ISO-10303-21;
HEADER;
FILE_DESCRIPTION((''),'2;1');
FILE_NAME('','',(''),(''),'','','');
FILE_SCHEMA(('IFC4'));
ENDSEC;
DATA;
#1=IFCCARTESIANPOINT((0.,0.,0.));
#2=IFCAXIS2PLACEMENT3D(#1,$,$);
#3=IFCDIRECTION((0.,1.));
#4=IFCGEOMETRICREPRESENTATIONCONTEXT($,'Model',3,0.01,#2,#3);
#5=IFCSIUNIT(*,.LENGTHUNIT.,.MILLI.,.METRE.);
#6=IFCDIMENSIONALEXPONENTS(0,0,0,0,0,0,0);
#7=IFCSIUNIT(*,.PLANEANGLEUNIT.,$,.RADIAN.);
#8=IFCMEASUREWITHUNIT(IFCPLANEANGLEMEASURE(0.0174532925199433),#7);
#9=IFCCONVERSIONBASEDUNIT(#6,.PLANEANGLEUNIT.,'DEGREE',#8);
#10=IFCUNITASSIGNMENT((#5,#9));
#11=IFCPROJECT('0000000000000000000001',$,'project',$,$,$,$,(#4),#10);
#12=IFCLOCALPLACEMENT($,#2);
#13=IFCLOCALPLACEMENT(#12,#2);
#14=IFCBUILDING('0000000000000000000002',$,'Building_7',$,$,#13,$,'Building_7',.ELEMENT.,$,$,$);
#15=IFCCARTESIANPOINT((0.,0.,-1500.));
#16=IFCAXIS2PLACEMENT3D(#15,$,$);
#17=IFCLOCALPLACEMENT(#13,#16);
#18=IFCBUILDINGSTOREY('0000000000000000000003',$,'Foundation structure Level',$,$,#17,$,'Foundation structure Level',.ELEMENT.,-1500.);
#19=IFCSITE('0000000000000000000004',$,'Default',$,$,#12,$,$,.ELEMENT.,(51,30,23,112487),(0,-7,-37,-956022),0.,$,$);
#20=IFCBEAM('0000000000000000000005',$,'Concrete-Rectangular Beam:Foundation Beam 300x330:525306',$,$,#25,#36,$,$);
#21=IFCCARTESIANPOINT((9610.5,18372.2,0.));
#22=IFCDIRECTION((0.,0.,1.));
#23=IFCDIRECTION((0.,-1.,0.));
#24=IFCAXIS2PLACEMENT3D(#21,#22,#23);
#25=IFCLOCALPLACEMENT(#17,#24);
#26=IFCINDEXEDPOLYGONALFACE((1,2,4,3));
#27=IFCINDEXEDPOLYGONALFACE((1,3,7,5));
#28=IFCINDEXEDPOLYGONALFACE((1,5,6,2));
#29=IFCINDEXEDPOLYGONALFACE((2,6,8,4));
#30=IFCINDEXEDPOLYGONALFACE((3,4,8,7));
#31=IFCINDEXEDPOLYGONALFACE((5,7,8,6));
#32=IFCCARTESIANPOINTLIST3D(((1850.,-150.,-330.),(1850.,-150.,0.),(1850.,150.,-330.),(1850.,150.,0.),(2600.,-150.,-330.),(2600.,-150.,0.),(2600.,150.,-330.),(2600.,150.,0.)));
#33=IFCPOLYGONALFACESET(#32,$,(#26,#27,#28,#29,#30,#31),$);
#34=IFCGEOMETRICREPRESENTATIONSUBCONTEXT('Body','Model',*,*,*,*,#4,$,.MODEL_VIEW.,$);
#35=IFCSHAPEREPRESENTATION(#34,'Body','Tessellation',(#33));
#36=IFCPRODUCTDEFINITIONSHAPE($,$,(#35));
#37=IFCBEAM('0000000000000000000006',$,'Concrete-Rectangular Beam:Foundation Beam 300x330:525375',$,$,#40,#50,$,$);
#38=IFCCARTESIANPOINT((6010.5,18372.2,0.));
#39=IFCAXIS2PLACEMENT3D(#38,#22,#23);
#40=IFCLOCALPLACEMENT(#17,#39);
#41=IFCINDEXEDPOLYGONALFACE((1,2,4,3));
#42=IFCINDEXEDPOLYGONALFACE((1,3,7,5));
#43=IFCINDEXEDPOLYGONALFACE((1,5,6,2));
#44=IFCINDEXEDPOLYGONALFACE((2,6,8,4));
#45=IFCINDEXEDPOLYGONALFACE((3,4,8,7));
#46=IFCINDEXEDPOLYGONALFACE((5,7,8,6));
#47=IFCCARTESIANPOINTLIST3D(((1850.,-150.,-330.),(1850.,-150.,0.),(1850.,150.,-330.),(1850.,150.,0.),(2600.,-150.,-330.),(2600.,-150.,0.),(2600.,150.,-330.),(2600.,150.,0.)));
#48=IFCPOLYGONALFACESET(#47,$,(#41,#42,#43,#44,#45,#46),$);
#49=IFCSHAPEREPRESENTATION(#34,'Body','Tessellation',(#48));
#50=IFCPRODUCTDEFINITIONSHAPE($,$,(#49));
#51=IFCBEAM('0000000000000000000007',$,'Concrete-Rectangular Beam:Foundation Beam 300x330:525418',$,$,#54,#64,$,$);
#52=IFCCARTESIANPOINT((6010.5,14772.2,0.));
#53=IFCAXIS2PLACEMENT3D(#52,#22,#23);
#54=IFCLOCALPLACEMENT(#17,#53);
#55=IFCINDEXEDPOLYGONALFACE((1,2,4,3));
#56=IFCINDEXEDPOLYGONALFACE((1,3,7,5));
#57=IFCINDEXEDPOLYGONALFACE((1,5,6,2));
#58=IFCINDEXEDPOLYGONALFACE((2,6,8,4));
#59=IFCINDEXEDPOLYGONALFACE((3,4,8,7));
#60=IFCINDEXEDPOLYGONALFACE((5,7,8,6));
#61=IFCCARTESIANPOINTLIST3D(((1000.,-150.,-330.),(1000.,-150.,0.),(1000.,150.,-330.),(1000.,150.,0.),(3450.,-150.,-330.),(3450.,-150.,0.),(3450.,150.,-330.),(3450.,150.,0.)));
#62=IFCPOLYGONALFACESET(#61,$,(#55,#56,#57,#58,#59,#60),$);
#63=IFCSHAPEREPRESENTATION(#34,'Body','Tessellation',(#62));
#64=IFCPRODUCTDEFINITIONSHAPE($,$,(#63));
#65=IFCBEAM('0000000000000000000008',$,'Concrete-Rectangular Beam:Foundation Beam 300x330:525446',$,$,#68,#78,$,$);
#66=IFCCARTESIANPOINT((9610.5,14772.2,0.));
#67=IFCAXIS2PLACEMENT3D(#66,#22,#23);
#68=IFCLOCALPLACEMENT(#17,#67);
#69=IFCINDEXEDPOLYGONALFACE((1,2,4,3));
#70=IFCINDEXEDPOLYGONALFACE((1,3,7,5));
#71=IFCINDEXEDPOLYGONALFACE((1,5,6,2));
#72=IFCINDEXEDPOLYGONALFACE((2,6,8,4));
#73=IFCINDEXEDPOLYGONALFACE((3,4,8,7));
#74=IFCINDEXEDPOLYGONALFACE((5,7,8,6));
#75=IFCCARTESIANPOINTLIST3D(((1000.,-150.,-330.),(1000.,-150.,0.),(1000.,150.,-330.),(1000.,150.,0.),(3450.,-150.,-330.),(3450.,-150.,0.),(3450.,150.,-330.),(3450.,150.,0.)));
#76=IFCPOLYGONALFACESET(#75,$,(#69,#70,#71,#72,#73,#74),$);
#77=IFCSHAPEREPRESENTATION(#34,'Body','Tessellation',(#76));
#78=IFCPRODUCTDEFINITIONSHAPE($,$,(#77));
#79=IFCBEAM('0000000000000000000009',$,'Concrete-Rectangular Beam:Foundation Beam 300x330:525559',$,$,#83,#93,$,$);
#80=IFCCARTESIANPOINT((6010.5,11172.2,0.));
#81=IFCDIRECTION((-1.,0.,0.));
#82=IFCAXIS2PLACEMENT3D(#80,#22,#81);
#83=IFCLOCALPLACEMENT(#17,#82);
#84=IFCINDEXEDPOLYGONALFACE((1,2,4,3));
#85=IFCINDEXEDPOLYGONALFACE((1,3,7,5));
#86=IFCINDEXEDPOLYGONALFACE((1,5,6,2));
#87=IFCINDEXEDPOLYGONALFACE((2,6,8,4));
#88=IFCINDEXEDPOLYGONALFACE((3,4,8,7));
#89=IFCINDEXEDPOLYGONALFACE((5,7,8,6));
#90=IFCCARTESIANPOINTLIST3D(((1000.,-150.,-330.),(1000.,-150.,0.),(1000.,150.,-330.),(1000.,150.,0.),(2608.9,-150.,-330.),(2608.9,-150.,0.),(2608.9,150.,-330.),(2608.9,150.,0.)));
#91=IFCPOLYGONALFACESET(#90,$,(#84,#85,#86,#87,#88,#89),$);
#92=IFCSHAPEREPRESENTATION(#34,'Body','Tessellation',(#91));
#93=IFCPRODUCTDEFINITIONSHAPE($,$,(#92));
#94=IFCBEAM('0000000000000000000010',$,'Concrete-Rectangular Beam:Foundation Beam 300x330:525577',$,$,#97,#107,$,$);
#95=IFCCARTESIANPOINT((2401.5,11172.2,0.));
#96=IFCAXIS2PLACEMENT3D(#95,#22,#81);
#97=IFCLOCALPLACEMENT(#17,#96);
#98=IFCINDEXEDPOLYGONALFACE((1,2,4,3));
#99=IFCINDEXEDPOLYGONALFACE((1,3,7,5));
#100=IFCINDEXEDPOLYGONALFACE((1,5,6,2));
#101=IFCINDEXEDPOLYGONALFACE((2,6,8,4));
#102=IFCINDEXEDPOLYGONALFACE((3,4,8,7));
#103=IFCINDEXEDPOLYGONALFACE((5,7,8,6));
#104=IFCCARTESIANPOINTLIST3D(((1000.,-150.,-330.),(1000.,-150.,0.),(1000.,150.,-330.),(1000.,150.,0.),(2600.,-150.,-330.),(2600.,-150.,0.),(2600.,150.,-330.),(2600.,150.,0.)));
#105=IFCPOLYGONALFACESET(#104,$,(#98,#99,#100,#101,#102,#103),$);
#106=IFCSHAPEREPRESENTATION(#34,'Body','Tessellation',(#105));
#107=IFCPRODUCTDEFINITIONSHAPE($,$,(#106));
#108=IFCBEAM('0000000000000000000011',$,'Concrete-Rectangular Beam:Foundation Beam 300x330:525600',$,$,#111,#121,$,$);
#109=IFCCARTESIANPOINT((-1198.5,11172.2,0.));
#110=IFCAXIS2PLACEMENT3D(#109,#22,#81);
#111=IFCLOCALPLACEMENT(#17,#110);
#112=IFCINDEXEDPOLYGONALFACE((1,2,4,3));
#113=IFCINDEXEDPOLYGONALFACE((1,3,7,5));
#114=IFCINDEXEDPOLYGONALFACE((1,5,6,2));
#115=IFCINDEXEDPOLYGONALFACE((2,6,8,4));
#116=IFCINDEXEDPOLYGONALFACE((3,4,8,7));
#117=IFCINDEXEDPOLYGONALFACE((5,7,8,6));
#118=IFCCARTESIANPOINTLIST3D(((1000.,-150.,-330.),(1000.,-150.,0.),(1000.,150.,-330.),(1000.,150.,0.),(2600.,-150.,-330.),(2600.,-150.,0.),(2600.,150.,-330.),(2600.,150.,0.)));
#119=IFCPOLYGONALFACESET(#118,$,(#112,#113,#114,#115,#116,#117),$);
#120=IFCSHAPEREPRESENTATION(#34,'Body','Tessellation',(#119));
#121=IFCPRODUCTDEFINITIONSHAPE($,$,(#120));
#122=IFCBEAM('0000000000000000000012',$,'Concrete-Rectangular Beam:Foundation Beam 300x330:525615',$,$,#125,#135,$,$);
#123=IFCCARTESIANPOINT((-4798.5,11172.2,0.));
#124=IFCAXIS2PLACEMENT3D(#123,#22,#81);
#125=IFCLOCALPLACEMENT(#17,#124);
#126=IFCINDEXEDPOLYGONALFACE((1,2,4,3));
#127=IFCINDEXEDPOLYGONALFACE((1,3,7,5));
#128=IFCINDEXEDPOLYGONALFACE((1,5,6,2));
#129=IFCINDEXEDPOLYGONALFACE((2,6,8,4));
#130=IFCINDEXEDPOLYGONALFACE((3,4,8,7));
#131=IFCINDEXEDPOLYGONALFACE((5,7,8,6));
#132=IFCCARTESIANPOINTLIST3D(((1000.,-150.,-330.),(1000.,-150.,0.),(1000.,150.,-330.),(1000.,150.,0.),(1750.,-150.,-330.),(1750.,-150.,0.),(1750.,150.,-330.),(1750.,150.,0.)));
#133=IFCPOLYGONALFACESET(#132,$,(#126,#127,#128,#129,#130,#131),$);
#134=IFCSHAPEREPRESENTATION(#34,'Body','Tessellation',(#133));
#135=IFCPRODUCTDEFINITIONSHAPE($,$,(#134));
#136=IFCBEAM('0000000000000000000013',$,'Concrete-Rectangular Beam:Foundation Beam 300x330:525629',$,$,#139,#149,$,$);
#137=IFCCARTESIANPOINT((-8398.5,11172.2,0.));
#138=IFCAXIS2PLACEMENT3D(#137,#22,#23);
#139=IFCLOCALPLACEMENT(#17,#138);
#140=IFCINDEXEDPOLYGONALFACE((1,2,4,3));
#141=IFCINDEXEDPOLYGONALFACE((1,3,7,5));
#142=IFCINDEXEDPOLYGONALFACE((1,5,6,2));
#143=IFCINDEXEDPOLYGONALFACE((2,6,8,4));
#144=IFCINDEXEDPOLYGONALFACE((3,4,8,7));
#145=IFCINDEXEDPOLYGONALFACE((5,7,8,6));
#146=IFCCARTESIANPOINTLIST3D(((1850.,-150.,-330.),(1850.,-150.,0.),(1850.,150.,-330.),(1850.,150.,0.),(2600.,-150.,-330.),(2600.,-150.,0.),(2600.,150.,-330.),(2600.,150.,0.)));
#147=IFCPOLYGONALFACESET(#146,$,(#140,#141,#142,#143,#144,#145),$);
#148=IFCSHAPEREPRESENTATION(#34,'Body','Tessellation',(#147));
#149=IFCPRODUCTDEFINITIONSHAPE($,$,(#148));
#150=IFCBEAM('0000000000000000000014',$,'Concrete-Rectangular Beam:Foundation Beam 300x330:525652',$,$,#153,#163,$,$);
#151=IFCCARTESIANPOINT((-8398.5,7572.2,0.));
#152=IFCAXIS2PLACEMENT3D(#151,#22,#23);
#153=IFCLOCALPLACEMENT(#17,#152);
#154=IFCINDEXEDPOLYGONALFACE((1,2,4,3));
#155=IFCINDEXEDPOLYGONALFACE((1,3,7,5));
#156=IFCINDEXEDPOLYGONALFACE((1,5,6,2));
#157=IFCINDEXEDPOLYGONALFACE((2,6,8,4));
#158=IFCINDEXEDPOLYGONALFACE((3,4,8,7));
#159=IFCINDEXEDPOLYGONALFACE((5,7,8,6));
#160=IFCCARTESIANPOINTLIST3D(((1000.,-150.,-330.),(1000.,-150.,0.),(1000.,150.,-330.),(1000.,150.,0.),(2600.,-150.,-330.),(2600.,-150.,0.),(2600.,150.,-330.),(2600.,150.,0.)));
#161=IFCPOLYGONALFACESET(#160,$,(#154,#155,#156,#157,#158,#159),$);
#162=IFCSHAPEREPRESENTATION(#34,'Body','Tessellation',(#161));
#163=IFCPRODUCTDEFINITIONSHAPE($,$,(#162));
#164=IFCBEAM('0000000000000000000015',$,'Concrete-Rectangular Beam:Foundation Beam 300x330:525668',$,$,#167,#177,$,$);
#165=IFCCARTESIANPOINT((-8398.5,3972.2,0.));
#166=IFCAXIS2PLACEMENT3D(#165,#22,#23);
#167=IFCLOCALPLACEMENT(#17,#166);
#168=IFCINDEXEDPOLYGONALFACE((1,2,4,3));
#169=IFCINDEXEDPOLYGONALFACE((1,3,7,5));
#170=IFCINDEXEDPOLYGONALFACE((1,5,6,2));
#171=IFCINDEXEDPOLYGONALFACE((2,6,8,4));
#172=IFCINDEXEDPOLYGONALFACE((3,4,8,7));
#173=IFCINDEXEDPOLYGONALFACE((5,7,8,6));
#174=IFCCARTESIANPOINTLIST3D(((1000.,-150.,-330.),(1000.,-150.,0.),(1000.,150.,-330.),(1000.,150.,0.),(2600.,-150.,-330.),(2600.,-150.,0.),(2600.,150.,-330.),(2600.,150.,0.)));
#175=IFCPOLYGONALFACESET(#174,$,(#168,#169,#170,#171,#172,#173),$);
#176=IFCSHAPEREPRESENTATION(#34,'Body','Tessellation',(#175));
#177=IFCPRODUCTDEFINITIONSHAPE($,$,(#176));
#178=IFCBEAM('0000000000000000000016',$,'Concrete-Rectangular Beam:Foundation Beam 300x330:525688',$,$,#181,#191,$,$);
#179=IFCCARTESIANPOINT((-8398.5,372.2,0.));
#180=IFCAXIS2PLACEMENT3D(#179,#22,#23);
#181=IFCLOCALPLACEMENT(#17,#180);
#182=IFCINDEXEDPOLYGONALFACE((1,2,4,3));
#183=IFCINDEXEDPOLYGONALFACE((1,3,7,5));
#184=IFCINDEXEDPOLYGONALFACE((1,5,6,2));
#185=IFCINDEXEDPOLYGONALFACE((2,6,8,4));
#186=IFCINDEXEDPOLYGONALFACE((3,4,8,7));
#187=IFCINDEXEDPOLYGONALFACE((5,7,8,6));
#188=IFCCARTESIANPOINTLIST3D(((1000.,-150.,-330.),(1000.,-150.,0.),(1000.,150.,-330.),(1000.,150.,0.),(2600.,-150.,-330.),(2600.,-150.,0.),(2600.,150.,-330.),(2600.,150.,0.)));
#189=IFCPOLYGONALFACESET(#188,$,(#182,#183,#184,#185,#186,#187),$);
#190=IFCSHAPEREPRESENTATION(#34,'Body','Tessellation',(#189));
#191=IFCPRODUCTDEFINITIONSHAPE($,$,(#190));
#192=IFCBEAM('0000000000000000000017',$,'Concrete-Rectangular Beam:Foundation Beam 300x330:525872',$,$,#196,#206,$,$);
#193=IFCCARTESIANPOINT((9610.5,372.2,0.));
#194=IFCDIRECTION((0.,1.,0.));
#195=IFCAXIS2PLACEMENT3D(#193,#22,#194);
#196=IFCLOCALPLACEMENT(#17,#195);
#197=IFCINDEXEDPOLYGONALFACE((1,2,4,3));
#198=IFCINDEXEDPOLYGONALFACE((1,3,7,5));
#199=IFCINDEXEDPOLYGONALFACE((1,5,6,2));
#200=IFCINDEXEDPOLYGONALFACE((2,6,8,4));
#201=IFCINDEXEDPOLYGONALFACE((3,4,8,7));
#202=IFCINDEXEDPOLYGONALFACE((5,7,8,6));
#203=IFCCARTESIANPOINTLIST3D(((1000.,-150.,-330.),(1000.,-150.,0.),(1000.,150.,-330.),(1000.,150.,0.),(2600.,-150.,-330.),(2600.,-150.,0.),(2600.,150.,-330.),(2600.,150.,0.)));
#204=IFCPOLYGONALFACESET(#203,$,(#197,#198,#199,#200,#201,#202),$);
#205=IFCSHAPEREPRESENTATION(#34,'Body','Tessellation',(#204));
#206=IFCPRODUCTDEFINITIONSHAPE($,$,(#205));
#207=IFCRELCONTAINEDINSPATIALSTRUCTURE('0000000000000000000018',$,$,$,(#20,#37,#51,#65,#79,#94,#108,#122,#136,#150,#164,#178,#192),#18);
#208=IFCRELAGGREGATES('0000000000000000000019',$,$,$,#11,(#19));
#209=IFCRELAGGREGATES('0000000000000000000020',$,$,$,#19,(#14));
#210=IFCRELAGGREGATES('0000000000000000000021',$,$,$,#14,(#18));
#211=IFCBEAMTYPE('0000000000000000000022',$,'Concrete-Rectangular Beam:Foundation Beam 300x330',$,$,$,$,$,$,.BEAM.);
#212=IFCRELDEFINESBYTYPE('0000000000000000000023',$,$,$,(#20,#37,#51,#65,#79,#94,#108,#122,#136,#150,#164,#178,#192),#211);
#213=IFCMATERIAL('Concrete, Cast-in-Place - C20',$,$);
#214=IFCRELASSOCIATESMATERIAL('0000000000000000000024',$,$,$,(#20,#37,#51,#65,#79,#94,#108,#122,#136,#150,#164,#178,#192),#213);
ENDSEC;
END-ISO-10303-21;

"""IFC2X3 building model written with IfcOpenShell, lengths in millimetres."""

from ifc_helpers import new_model, entity, si_unit, converted_unit, direction, frame, frame_2d, origin, place, context, subcontext, project, spatial, rectangle, extrude, material, type_object, element, save


model = new_model("IFC2X3")

# Units and contexts
model_context = context("Model", 3, precision=0.01, world=origin(), true_north=direction((0.0, 1.0)))
body_context = subcontext(model_context, "Body", "Model", "MODEL_VIEW")
ifc_project = project(units=[si_unit("LENGTHUNIT", "METRE", prefix="MILLI"), converted_unit("PLANEANGLEUNIT", "DEGREE", entity("IfcPlaneAngleMeasure", 0.0174532925199433), si_unit("PLANEANGLEUNIT", "RADIAN"), dimensions=[0, 0, 0, 0, 0, 0, 0])], contexts=[model_context])

# Site, building, storey
site_placement = place(None, origin())
site = spatial("IfcSite", under=ifc_project, at=site_placement, Name="Default", CompositionType="ELEMENT", RefLatitude=(51, 30, 23, 112487), RefLongitude=(0, -7, -37, -956022), RefElevation=0.0)
building_placement = place(site_placement, origin())
building = spatial("IfcBuilding", under=site, at=building_placement, Name="Building_7", LongName="Building_7", CompositionType="ELEMENT")
storey_placement = place(building_placement, frame((0.0, 0.0, -1500.0)))
storey = spatial("IfcBuildingStorey", under=building, at=storey_placement, Name="Foundation structure Level", LongName="Foundation structure Level", CompositionType="ELEMENT", Elevation=-1500.0)

# Beams
ifc_material_1 = material(Name="Concrete, Cast-in-Place - C20")
beam_type = type_object("IfcBeamType", Name="Concrete-Rectangular Beam:Foundation Beam 300x330", PredefinedType="BEAM")
beam_1_placement = place(storey_placement, frame((9610.5, 18372.2, 0.0), z_axis=(0.0, 0.0, 1.0), x_axis=(0.0, -1.0, 0.0)))
element("IfcBeam", 1, at=beam_1_placement, inside=storey, type_object=beam_type, material=ifc_material_1, Name="Concrete-Rectangular Beam:Foundation Beam 300x330:525306", context=body_context, shape_type="SweptSolid", body=[
    extrude(rectangle(XDim=330.0, YDim=300.0, at=frame_2d((0.0, 0.0), x_axis=(1.0, 0.0))), frame((1850.0, 0.0, -165.0), z_axis=(1.0, 0.0, 0.0), x_axis=(0.0, 0.0, -1.0)), (0.0, 0.0, 1.0), 750.0),
])
beam_2_placement = place(storey_placement, frame((6010.5, 18372.2, 0.0), z_axis=(0.0, 0.0, 1.0), x_axis=(0.0, -1.0, 0.0)))
element("IfcBeam", 2, at=beam_2_placement, inside=storey, type_object=beam_type, material=ifc_material_1, Name="Concrete-Rectangular Beam:Foundation Beam 300x330:525375", context=body_context, shape_type="SweptSolid", body=[
    extrude(rectangle(XDim=330.0, YDim=300.0, at=frame_2d((0.0, 0.0), x_axis=(1.0, 0.0))), frame((1850.0, 0.0, -165.0), z_axis=(1.0, 0.0, 0.0), x_axis=(0.0, 0.0, -1.0)), (0.0, 0.0, 1.0), 750.0),
])
beam_3_placement = place(storey_placement, frame((6010.5, 14772.2, 0.0), z_axis=(0.0, 0.0, 1.0), x_axis=(0.0, -1.0, 0.0)))
element("IfcBeam", 3, at=beam_3_placement, inside=storey, type_object=beam_type, material=ifc_material_1, Name="Concrete-Rectangular Beam:Foundation Beam 300x330:525418", context=body_context, shape_type="SweptSolid", body=[
    extrude(rectangle(XDim=330.0, YDim=300.0, at=frame_2d((0.0, 0.0), x_axis=(1.0, 0.0))), frame((1000.0, 0.0, -165.0), z_axis=(1.0, 0.0, 0.0), x_axis=(0.0, 0.0, -1.0)), (0.0, 0.0, 1.0), 2450.0),
])
beam_4_placement = place(storey_placement, frame((9610.5, 14772.2, 0.0), z_axis=(0.0, 0.0, 1.0), x_axis=(0.0, -1.0, 0.0)))
element("IfcBeam", 4, at=beam_4_placement, inside=storey, type_object=beam_type, material=ifc_material_1, Name="Concrete-Rectangular Beam:Foundation Beam 300x330:525446", context=body_context, shape_type="SweptSolid", body=[
    extrude(rectangle(XDim=330.0, YDim=300.0, at=frame_2d((0.0, 0.0), x_axis=(1.0, 0.0))), frame((1000.0, 0.0, -165.0), z_axis=(1.0, 0.0, 0.0), x_axis=(0.0, 0.0, -1.0)), (0.0, 0.0, 1.0), 2450.0),
])
beam_5_placement = place(storey_placement, frame((6010.5, 11172.2, 0.0), z_axis=(0.0, 0.0, 1.0), x_axis=(-1.0, 0.0, 0.0)))
element("IfcBeam", 5, at=beam_5_placement, inside=storey, type_object=beam_type, material=ifc_material_1, Name="Concrete-Rectangular Beam:Foundation Beam 300x330:525559", context=body_context, shape_type="SweptSolid", body=[
    extrude(rectangle(XDim=330.0, YDim=300.0, at=frame_2d((0.0, 0.0), x_axis=(1.0, 0.0))), frame((1000.0, 0.0, -165.0), z_axis=(1.0, 0.0, 0.0), x_axis=(0.0, 0.0, -1.0)), (0.0, 0.0, 1.0), 1608.9),
])
for number, where, z_axis, x_axis, name in (
    (6, (2401.5, 11172.2, 0.0), (0.0, 0.0, 1.0), (-1.0, 0.0, 0.0), "Concrete-Rectangular Beam:Foundation Beam 300x330:525577"),
    (7, (-1198.5, 11172.2, 0.0), (0.0, 0.0, 1.0), (-1.0, 0.0, 0.0), "Concrete-Rectangular Beam:Foundation Beam 300x330:525600"),
):
    element("IfcBeam", number, at=place(storey_placement, frame(where, z_axis=z_axis, x_axis=x_axis)), inside=storey, type_object=beam_type, material=ifc_material_1, Name=name, context=body_context, shape_type="SweptSolid", body=[
        extrude(rectangle(XDim=330.0, YDim=300.0, at=frame_2d((0.0, 0.0), x_axis=(1.0, 0.0))), frame((1000.0, 0.0, -165.0), z_axis=(1.0, 0.0, 0.0), x_axis=(0.0, 0.0, -1.0)), (0.0, 0.0, 1.0), 1600.0),
    ])
beam_6_placement = place(storey_placement, frame((-4798.5, 11172.2, 0.0), z_axis=(0.0, 0.0, 1.0), x_axis=(-1.0, 0.0, 0.0)))
element("IfcBeam", 8, at=beam_6_placement, inside=storey, type_object=beam_type, material=ifc_material_1, Name="Concrete-Rectangular Beam:Foundation Beam 300x330:525615", context=body_context, shape_type="SweptSolid", body=[
    extrude(rectangle(XDim=330.0, YDim=300.0, at=frame_2d((0.0, 0.0), x_axis=(1.0, 0.0))), frame((1000.0, 0.0, -165.0), z_axis=(1.0, 0.0, 0.0), x_axis=(0.0, 0.0, -1.0)), (0.0, 0.0, 1.0), 750.0),
])
beam_7_placement = place(storey_placement, frame((-8398.5, 11172.2, 0.0), z_axis=(0.0, 0.0, 1.0), x_axis=(0.0, -1.0, 0.0)))
element("IfcBeam", 9, at=beam_7_placement, inside=storey, type_object=beam_type, material=ifc_material_1, Name="Concrete-Rectangular Beam:Foundation Beam 300x330:525629", context=body_context, shape_type="SweptSolid", body=[
    extrude(rectangle(XDim=330.0, YDim=300.0, at=frame_2d((0.0, 0.0), x_axis=(1.0, 0.0))), frame((1850.0, 0.0, -165.0), z_axis=(1.0, 0.0, 0.0), x_axis=(0.0, 0.0, -1.0)), (0.0, 0.0, 1.0), 750.0),
])
for number, where, z_axis, x_axis, name in (
    (10, (-8398.5, 7572.2, 0.0), (0.0, 0.0, 1.0), (0.0, -1.0, 0.0), "Concrete-Rectangular Beam:Foundation Beam 300x330:525652"),
    (11, (-8398.5, 3972.2, 0.0), (0.0, 0.0, 1.0), (0.0, -1.0, 0.0), "Concrete-Rectangular Beam:Foundation Beam 300x330:525668"),
    (12, (-8398.5, 372.2, 0.0), (0.0, 0.0, 1.0), (0.0, -1.0, 0.0), "Concrete-Rectangular Beam:Foundation Beam 300x330:525688"),
):
    element("IfcBeam", number, at=place(storey_placement, frame(where, z_axis=z_axis, x_axis=x_axis)), inside=storey, type_object=beam_type, material=ifc_material_1, Name=name, context=body_context, shape_type="SweptSolid", body=[
        extrude(rectangle(XDim=330.0, YDim=300.0, at=frame_2d((0.0, 0.0), x_axis=(1.0, 0.0))), frame((1000.0, 0.0, -165.0), z_axis=(1.0, 0.0, 0.0), x_axis=(0.0, 0.0, -1.0)), (0.0, 0.0, 1.0), 1600.0),
    ])
beam_8_placement = place(storey_placement, frame((9610.5, 372.2, 0.0), z_axis=(0.0, 0.0, 1.0), x_axis=(0.0, 1.0, 0.0)))
element("IfcBeam", 13, at=beam_8_placement, inside=storey, type_object=beam_type, material=ifc_material_1, Name="Concrete-Rectangular Beam:Foundation Beam 300x330:525872", context=body_context, shape_type="SweptSolid", body=[
    extrude(rectangle(XDim=330.0, YDim=300.0, at=frame_2d((0.0, 0.0), x_axis=(1.0, 0.0))), frame((1000.0, 0.0, -165.0), z_axis=(1.0, 0.0, 0.0), x_axis=(0.0, 0.0, -1.0)), (0.0, 0.0, 1.0), 1600.0),
])

save(model, "model.ifc")
